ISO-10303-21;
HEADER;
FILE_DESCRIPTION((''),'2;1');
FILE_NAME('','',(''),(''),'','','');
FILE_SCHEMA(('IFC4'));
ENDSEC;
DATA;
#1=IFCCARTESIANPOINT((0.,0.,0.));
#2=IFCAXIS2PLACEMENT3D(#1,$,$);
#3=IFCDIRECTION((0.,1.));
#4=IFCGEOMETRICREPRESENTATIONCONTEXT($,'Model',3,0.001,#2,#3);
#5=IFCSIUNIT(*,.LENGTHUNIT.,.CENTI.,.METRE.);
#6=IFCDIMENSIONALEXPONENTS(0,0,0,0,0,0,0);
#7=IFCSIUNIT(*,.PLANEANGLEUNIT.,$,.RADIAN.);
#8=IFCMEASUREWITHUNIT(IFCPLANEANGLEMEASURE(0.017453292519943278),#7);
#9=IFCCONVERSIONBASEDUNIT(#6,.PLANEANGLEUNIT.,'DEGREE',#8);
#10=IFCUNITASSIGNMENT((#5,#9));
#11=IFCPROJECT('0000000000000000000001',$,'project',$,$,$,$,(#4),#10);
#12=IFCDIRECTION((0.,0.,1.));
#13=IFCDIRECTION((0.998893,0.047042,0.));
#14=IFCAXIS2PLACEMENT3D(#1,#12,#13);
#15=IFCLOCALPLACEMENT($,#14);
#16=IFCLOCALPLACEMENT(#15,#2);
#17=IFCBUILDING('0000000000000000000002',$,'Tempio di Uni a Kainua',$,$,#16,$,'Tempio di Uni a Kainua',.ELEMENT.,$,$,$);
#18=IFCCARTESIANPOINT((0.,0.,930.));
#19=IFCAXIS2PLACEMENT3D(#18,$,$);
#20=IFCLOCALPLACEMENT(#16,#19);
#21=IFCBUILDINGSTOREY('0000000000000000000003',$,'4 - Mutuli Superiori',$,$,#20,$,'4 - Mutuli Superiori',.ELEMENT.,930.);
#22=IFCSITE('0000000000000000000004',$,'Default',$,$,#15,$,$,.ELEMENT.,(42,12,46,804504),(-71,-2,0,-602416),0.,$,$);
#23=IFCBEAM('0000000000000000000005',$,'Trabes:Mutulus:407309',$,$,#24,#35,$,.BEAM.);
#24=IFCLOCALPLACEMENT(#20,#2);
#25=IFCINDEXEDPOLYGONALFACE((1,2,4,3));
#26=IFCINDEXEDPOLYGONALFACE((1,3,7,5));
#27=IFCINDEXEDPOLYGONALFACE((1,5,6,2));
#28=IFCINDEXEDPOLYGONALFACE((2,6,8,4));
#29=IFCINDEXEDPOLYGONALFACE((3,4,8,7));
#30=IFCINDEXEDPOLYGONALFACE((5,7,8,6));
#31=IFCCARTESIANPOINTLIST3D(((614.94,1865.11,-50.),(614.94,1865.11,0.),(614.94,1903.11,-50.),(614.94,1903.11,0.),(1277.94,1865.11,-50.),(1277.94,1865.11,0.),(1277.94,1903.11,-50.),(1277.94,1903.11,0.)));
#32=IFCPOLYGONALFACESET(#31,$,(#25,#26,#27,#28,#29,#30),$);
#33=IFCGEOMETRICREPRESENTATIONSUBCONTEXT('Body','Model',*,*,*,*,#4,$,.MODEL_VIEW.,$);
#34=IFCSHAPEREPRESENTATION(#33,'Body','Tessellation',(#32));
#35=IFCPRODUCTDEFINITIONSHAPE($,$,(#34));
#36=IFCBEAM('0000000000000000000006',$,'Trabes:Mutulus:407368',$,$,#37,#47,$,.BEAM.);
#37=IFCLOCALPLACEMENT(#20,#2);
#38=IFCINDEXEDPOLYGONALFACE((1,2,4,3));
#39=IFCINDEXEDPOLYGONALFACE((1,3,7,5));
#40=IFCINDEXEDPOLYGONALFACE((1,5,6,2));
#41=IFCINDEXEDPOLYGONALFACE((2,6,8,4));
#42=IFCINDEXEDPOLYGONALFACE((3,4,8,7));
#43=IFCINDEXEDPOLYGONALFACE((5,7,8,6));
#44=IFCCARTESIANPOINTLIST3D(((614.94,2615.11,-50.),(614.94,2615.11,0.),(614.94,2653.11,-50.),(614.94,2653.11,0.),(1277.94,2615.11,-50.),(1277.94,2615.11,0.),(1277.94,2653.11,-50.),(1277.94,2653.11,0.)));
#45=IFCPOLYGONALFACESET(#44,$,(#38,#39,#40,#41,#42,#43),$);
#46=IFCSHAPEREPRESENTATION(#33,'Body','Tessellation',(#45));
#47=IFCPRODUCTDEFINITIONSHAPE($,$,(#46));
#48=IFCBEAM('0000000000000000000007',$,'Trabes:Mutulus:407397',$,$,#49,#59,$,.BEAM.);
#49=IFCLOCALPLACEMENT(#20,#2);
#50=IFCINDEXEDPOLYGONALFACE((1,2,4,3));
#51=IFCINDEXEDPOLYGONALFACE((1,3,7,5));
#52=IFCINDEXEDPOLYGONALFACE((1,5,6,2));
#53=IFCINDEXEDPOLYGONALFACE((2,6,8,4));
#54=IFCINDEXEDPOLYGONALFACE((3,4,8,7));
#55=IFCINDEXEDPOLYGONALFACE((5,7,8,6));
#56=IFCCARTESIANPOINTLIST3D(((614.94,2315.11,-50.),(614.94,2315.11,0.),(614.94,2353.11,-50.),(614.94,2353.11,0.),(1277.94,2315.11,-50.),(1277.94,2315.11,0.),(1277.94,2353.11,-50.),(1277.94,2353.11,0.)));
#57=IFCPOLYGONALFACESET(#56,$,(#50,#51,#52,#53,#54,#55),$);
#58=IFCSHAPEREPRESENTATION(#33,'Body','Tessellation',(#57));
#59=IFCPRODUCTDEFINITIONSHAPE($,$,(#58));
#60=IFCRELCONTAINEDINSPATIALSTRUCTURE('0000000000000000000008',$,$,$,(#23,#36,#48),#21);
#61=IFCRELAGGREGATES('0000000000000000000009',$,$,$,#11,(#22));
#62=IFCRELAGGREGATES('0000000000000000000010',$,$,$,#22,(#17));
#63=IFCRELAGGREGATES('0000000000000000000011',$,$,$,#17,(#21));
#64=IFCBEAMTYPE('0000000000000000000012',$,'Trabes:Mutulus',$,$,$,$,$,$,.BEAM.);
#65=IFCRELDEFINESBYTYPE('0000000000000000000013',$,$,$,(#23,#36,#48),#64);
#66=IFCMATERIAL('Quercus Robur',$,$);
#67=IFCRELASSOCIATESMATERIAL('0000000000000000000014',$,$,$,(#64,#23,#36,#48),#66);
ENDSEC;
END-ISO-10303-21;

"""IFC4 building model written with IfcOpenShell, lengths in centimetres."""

from ifc_helpers import new_model, entity, si_unit, converted_unit, direction, frame, origin, origin_2d_with_axis, place, context, subcontext, project, spatial, rectangle, extrude, source, transform, mapped, material, material_profile, profile_set, profile_usage, type_object, type_shapes, element, save


model = new_model("IFC4")

# Units and contexts
model_context = context("Model", 3, precision=0.001, world=origin(), true_north=direction((0.0, 1.0)))
body_context = subcontext(model_context, "Body", "Model", "MODEL_VIEW")
ifc_project = project(units=[si_unit("LENGTHUNIT", "METRE", prefix="CENTI"), converted_unit("PLANEANGLEUNIT", "DEGREE", entity("IfcPlaneAngleMeasure", 0.017453292519943278), si_unit("PLANEANGLEUNIT", "RADIAN"), dimensions=[0, 0, 0, 0, 0, 0, 0])], contexts=[model_context])

# Site, building, storey
site_placement = place(None, frame((0.0, 0.0, 0.0), z_axis=(0.0, 0.0, 1.0), x_axis=(0.998893, 0.047042, 0.0)))
site = spatial("IfcSite", under=ifc_project, at=site_placement, Name="Default", CompositionType="ELEMENT", RefLatitude=(42, 12, 46, 804504), RefLongitude=(-71, -2, 0, -602416), RefElevation=0.0)
building_placement = place(site_placement, origin())
building = spatial("IfcBuilding", under=site, at=building_placement, Name="Tempio di Uni a Kainua", LongName="Tempio di Uni a Kainua", CompositionType="ELEMENT")
storey_placement = place(building_placement, frame((0.0, 0.0, 930.0)))
storey = spatial("IfcBuildingStorey", under=building, at=storey_placement, Name="4 - Mutuli Superiori", LongName="4 - Mutuli Superiori", CompositionType="ELEMENT", Elevation=930.0)

# Beams
ifc_material = material(Name="Quercus Robur")
ifc_material_profile = material_profile(ifc_material, rectangle(XDim=2814.5, YDim=38.0, at=origin_2d_with_axis()), Name="Mutulus")
ifc_profile_set = profile_set([ifc_material_profile], Name="Mutulus")
ifc_profile_usage_1 = profile_usage(ifc_profile_set, cardinal=8)
beam_type_1 = type_object("IfcBeamType", Name="Trabes:Mutulus", PredefinedType="BEAM", material=ifc_profile_set)
shared_shape_1 = source(origin(), body_context, "Body", "SweptSolid", [
    extrude(rectangle(XDim=663.0, YDim=38.0, at=origin_2d_with_axis()), frame((0.0, 0.0, -25.0)), (0.0, 0.0, 1.0), 50.0),
])
type_shapes(beam_type_1, [shared_shape_1])
for number, where, name in (
    (1, (946.44, 1884.11, -25.0), "Trabes:Mutulus:407309"),
    (2, (946.44, 2634.11, -25.0), "Trabes:Mutulus:407368"),
    (3, (946.44, 2334.11, -25.0), "Trabes:Mutulus:407397"),
):
    element("IfcBeam", number, at=place(storey_placement, frame(where)), inside=storey, type_object=beam_type_1, material=ifc_profile_usage_1, Name=name, PredefinedType="BEAM", context=body_context, shape_type="MappedRepresentation", body=[
        mapped(shared_shape_1, transform((0.0, 0.0, 0.0), scale=1.0)),
    ])

save(model, "model.ifc")
